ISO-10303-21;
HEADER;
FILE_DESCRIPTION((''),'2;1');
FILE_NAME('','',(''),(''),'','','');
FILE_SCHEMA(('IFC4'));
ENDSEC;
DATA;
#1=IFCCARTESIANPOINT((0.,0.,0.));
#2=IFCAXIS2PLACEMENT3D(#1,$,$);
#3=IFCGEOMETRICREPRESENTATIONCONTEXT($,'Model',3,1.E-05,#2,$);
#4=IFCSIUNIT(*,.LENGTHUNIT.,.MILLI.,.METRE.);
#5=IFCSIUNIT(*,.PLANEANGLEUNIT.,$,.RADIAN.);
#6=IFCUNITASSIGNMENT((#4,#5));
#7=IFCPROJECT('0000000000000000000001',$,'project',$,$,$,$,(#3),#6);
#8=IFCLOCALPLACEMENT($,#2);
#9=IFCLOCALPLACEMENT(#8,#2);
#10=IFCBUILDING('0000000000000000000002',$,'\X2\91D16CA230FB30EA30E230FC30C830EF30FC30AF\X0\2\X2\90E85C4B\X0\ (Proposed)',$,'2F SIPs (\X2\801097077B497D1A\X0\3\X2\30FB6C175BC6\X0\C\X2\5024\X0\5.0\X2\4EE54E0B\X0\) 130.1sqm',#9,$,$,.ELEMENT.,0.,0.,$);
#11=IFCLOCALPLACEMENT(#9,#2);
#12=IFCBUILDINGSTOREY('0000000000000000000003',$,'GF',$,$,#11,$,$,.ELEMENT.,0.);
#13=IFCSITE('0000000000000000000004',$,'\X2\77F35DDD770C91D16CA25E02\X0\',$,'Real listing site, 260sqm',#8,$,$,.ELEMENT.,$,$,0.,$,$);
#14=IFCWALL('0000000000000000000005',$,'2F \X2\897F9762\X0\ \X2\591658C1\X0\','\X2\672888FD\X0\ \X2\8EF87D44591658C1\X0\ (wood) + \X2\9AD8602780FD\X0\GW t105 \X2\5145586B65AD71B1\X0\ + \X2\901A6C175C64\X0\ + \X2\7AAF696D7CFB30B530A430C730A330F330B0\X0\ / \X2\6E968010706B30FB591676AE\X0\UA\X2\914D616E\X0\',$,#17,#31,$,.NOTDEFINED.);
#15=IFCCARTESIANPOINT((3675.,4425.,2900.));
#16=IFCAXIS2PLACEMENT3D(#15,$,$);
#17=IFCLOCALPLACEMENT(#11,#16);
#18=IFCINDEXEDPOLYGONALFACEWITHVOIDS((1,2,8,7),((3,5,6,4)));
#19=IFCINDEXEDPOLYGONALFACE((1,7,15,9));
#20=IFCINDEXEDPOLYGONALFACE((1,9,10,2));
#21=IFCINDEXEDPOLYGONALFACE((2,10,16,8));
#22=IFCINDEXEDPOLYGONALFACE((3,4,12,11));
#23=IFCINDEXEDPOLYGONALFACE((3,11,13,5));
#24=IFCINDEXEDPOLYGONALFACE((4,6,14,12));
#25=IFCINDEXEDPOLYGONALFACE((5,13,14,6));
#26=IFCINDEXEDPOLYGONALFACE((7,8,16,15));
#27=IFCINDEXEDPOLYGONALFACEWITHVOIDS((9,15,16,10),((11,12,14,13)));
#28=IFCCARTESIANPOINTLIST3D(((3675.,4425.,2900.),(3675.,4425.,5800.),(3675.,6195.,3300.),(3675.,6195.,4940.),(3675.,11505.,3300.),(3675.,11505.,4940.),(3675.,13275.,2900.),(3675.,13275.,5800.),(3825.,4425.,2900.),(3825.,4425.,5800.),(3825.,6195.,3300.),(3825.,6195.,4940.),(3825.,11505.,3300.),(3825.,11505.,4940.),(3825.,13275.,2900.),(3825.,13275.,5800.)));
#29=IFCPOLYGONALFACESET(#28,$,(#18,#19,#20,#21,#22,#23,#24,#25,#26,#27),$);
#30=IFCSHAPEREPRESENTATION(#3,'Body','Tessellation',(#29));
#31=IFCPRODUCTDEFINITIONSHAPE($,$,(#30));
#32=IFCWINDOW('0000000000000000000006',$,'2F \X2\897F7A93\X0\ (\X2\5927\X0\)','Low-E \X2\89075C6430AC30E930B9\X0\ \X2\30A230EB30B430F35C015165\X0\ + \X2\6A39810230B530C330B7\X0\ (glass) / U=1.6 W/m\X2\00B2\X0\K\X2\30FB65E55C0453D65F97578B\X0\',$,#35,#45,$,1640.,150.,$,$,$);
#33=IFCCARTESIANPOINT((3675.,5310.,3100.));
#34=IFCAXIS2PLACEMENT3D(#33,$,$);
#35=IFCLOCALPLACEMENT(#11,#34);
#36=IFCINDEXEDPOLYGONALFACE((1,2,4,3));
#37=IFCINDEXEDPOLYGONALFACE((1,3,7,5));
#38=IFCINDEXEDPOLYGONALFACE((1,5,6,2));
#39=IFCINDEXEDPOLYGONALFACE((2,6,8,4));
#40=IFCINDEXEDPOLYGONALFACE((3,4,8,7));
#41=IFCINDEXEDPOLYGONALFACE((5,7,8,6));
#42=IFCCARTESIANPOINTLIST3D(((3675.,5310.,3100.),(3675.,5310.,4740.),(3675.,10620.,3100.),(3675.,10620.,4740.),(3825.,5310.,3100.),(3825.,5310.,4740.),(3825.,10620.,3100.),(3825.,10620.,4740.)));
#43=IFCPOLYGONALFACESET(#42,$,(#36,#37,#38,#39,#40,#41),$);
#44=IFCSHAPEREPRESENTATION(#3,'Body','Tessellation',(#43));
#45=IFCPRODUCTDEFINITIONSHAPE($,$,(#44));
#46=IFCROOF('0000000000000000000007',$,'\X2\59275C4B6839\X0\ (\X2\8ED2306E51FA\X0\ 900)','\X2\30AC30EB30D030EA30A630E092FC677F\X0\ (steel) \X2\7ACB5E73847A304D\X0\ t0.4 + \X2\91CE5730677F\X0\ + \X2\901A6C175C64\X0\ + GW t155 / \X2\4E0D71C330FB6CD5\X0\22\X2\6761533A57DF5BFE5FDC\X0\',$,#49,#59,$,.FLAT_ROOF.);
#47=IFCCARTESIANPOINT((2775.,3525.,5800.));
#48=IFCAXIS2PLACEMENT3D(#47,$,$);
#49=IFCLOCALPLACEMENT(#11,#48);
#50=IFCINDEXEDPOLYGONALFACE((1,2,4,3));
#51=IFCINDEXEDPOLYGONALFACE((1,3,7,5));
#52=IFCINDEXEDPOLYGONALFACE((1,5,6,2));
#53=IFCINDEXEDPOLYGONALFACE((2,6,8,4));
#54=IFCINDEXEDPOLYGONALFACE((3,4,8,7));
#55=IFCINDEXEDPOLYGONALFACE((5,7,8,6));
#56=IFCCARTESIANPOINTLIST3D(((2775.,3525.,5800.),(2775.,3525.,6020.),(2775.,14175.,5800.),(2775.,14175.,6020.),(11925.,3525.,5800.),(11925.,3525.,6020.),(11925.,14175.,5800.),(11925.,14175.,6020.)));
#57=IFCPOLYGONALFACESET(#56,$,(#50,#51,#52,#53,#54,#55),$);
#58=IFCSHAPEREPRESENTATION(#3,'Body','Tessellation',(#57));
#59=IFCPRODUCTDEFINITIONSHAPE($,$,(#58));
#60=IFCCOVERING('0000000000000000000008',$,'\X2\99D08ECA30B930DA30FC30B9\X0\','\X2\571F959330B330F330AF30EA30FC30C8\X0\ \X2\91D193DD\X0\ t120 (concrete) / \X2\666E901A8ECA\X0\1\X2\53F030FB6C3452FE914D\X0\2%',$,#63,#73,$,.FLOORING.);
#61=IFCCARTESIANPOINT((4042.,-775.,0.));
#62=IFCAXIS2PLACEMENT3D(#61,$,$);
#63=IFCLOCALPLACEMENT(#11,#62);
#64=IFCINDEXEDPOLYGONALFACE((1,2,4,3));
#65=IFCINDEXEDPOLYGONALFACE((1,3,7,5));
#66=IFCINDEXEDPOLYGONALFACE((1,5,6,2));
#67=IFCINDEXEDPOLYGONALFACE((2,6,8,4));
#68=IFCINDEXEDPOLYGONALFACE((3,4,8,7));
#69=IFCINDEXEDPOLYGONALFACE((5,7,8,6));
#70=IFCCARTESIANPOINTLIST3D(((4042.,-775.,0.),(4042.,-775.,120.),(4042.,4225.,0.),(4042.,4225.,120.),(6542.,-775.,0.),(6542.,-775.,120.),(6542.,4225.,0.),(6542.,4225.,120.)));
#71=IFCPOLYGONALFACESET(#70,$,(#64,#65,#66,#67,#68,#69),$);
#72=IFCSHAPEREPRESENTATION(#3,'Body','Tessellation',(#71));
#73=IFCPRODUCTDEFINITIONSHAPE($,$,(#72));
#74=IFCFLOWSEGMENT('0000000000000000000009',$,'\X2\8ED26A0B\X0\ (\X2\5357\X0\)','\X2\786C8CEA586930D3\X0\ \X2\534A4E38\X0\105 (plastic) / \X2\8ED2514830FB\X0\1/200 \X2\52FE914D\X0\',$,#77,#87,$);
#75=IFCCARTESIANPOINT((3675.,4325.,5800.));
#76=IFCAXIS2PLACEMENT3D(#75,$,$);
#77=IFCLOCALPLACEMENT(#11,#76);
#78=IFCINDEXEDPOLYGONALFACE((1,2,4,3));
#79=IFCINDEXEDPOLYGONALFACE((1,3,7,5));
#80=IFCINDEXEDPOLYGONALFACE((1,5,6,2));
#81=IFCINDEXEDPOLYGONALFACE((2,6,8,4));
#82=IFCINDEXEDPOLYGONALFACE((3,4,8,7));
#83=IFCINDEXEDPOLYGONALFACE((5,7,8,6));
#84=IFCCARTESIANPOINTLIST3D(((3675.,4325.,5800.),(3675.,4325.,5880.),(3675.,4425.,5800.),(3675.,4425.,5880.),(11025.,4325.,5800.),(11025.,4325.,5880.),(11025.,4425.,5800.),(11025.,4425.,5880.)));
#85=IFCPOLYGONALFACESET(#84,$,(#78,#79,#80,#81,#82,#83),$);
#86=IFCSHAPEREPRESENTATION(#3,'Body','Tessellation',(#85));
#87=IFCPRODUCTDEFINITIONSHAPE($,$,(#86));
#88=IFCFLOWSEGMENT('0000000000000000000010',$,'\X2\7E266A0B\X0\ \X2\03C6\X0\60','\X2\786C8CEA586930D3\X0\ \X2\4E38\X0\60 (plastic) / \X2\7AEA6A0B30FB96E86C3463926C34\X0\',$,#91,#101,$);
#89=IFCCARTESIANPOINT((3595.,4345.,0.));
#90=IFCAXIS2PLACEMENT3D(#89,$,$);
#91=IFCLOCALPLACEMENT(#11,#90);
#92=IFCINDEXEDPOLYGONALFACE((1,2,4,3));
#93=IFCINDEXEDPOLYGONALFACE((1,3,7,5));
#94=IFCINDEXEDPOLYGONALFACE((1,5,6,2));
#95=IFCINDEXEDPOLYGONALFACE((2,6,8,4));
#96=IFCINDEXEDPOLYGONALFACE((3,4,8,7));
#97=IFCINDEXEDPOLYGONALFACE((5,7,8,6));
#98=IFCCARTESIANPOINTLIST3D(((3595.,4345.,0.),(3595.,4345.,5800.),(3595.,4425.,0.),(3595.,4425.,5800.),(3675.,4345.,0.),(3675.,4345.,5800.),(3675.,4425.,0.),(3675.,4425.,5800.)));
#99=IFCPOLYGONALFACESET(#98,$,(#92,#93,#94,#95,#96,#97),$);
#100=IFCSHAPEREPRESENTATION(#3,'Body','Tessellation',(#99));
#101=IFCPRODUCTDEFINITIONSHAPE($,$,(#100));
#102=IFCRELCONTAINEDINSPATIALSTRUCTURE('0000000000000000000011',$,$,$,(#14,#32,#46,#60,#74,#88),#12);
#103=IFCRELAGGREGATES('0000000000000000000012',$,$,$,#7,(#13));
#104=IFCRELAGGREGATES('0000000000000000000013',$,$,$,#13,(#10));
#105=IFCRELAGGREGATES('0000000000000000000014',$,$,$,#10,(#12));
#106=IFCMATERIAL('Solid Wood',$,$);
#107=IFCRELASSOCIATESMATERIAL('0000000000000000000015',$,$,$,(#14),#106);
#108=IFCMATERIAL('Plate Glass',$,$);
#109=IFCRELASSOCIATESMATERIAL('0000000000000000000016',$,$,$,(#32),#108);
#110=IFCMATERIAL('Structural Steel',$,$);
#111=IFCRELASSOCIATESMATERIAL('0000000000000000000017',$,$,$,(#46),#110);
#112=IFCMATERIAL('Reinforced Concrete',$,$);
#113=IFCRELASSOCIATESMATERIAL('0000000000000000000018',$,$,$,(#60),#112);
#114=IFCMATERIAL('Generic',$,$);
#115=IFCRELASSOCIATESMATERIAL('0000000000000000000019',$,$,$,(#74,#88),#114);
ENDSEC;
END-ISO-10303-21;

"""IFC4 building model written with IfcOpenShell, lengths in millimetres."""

from ifc_helpers import new_model, si_unit, frame, frame_2d, origin, place, context, project, spatial, rectangle, extrude, material, element, fill, save


model = new_model("IFC4")

# Units and contexts
model_context = context("Model", 3, precision=1e-05, world=origin())
ifc_project = project(units=[si_unit("LENGTHUNIT", "METRE", prefix="MILLI"), si_unit("PLANEANGLEUNIT", "RADIAN")], contexts=[model_context])

# Site, building, storey
site_placement = place(None, origin())
site = spatial("IfcSite", under=ifc_project, at=site_placement, Name="石川県金沢市", ObjectType="Real listing site, 260sqm", CompositionType="ELEMENT", RefElevation=0.0)
building_placement = place(site_placement, origin())
building = spatial("IfcBuilding", under=site, at=building_placement, Name="金沢・リモートワーク2部屋 (Proposed)", ObjectType="2F SIPs (耐震等級3・気密C値5.0以下) 130.1sqm", CompositionType="ELEMENT", ElevationOfRefHeight=0.0, ElevationOfTerrain=0.0)
storey_placement = place(building_placement, origin())
storey = spatial("IfcBuildingStorey", under=building, at=storey_placement, Name="GF", CompositionType="ELEMENT", Elevation=0.0)

# Shared definitions
ifc_material_1 = material(Name="Solid Wood")

# Shared definitions
ifc_material_2 = material(Name="Reinforced Concrete")

# Shared definitions
ifc_material_3 = material(Name="Plate Glass")

# Wall, opening, window
wall_1_placement = place(storey_placement, frame((3675.0, 4425.0, 2900.0)))
wall_1 = element("IfcWall", 1, at=wall_1_placement, inside=storey, material=ifc_material_1, Name="2F 西面 外壁", Description="木製 軸組外壁 (wood) + 高性能GW t105 充填断熱 + 通気層 + 窯業系サイディング / 準耐火・外皮UA配慮", PredefinedType="NOTDEFINED", context=model_context, shape_type="SweptSolid", body=[
    extrude(rectangle(XDim=150.0, YDim=8850.0, at=frame_2d((75.0, 4425.0))), frame((3675.0, 4425.0, 2900.0)), (0.0, 0.0, 1.0), 2900.0),
])
opening_1_placement = place(storey_placement, frame((3675.0, 5310.0, 3100.0)))
opening_1 = element("IfcOpeningElement", 2, at=opening_1_placement, cuts=wall_1, PredefinedType="NOTDEFINED", context=model_context, shape_type="SweptSolid", body=[
    extrude(rectangle(XDim=150.0, YDim=5310.0, at=frame_2d((75.0, 2655.0))), frame((3675.0, 5310.0, 3100.0)), (0.0, 0.0, 1.0), 1640.0),
])
window_1_placement = place(storey_placement, frame((3675.0, 5310.0, 3100.0)))
window_1 = element("IfcWindow", 3, at=window_1_placement, inside=storey, material=ifc_material_3, Name="2F 西窓 (大)", Description="Low-E 複層ガラス アルゴン封入 + 樹脂サッシ (glass) / U=1.6 W/m²K・日射取得型", OverallHeight=1640.0, OverallWidth=150.0, context=model_context, shape_type="SweptSolid", body=[
    extrude(rectangle(XDim=150.0, YDim=5310.0, at=frame_2d((75.0, 2655.0))), frame((3675.0, 5310.0, 3100.0)), (0.0, 0.0, 1.0), 1640.0),
])
fill(opening_1, window_1)

# Roof
ifc_material_4 = material(Name="Structural Steel")
roof_placement = place(storey_placement, frame((2775.0, 3525.0, 5800.0)))
element("IfcRoof", 4, at=roof_placement, inside=storey, material=ifc_material_4, Name="大屋根 (軒の出 900)", Description="ガルバリウム鋼板 (steel) 立平葺き t0.4 + 野地板 + 通気層 + GW t155 / 不燃・法22条区域対応", PredefinedType="FLAT_ROOF", context=model_context, shape_type="SweptSolid", body=[
    extrude(rectangle(XDim=9150.0, YDim=10650.0, at=frame_2d((4575.0, 5325.0))), frame((2775.0, 3525.0, 5800.0)), (0.0, 0.0, 1.0), 220.0),
])

# Covering
covering_placement = place(storey_placement, frame((4042.0, -775.0, 0.0)))
element("IfcCovering", 5, at=covering_placement, inside=storey, material=ifc_material_2, Name="駐車スペース", Description="土間コンクリート 金鏝 t120 (concrete) / 普通車1台・水勾配2%", PredefinedType="FLOORING", context=model_context, shape_type="SweptSolid", body=[
    extrude(rectangle(XDim=2500.0, YDim=5000.0, at=frame_2d((1250.0, 2500.0))), frame((4042.0, -775.0, 0.0)), (0.0, 0.0, 1.0), 120.0),
])

# Flow segments
ifc_material_5 = material(Name="Generic")
flow_segment_1_placement = place(storey_placement, frame((3675.0, 4325.0, 5800.0)))
element("IfcFlowSegment", 6, at=flow_segment_1_placement, inside=storey, material=ifc_material_5, Name="軒樋 (南)", Description="硬質塩ビ 半丸105 (plastic) / 軒先・1/200 勾配", context=model_context, shape_type="SweptSolid", body=[
    extrude(rectangle(XDim=7350.0, YDim=100.0, at=frame_2d((3675.0, 50.0))), frame((3675.0, 4325.0, 5800.0)), (0.0, 0.0, 1.0), 80.0),
])
flow_segment_2_placement = place(storey_placement, frame((3595.0, 4345.0, 0.0)))
element("IfcFlowSegment", 7, at=flow_segment_2_placement, inside=storey, material=ifc_material_5, Name="縦樋 φ60", Description="硬質塩ビ 丸60 (plastic) / 竪樋・雨水排水", context=model_context, shape_type="SweptSolid", body=[
    extrude(rectangle(XDim=80.0, YDim=80.0, at=frame_2d((40.0, 40.0))), frame((3595.0, 4345.0, 0.0)), (0.0, 0.0, 1.0), 5800.0),
])

save(model, "model.ifc")
